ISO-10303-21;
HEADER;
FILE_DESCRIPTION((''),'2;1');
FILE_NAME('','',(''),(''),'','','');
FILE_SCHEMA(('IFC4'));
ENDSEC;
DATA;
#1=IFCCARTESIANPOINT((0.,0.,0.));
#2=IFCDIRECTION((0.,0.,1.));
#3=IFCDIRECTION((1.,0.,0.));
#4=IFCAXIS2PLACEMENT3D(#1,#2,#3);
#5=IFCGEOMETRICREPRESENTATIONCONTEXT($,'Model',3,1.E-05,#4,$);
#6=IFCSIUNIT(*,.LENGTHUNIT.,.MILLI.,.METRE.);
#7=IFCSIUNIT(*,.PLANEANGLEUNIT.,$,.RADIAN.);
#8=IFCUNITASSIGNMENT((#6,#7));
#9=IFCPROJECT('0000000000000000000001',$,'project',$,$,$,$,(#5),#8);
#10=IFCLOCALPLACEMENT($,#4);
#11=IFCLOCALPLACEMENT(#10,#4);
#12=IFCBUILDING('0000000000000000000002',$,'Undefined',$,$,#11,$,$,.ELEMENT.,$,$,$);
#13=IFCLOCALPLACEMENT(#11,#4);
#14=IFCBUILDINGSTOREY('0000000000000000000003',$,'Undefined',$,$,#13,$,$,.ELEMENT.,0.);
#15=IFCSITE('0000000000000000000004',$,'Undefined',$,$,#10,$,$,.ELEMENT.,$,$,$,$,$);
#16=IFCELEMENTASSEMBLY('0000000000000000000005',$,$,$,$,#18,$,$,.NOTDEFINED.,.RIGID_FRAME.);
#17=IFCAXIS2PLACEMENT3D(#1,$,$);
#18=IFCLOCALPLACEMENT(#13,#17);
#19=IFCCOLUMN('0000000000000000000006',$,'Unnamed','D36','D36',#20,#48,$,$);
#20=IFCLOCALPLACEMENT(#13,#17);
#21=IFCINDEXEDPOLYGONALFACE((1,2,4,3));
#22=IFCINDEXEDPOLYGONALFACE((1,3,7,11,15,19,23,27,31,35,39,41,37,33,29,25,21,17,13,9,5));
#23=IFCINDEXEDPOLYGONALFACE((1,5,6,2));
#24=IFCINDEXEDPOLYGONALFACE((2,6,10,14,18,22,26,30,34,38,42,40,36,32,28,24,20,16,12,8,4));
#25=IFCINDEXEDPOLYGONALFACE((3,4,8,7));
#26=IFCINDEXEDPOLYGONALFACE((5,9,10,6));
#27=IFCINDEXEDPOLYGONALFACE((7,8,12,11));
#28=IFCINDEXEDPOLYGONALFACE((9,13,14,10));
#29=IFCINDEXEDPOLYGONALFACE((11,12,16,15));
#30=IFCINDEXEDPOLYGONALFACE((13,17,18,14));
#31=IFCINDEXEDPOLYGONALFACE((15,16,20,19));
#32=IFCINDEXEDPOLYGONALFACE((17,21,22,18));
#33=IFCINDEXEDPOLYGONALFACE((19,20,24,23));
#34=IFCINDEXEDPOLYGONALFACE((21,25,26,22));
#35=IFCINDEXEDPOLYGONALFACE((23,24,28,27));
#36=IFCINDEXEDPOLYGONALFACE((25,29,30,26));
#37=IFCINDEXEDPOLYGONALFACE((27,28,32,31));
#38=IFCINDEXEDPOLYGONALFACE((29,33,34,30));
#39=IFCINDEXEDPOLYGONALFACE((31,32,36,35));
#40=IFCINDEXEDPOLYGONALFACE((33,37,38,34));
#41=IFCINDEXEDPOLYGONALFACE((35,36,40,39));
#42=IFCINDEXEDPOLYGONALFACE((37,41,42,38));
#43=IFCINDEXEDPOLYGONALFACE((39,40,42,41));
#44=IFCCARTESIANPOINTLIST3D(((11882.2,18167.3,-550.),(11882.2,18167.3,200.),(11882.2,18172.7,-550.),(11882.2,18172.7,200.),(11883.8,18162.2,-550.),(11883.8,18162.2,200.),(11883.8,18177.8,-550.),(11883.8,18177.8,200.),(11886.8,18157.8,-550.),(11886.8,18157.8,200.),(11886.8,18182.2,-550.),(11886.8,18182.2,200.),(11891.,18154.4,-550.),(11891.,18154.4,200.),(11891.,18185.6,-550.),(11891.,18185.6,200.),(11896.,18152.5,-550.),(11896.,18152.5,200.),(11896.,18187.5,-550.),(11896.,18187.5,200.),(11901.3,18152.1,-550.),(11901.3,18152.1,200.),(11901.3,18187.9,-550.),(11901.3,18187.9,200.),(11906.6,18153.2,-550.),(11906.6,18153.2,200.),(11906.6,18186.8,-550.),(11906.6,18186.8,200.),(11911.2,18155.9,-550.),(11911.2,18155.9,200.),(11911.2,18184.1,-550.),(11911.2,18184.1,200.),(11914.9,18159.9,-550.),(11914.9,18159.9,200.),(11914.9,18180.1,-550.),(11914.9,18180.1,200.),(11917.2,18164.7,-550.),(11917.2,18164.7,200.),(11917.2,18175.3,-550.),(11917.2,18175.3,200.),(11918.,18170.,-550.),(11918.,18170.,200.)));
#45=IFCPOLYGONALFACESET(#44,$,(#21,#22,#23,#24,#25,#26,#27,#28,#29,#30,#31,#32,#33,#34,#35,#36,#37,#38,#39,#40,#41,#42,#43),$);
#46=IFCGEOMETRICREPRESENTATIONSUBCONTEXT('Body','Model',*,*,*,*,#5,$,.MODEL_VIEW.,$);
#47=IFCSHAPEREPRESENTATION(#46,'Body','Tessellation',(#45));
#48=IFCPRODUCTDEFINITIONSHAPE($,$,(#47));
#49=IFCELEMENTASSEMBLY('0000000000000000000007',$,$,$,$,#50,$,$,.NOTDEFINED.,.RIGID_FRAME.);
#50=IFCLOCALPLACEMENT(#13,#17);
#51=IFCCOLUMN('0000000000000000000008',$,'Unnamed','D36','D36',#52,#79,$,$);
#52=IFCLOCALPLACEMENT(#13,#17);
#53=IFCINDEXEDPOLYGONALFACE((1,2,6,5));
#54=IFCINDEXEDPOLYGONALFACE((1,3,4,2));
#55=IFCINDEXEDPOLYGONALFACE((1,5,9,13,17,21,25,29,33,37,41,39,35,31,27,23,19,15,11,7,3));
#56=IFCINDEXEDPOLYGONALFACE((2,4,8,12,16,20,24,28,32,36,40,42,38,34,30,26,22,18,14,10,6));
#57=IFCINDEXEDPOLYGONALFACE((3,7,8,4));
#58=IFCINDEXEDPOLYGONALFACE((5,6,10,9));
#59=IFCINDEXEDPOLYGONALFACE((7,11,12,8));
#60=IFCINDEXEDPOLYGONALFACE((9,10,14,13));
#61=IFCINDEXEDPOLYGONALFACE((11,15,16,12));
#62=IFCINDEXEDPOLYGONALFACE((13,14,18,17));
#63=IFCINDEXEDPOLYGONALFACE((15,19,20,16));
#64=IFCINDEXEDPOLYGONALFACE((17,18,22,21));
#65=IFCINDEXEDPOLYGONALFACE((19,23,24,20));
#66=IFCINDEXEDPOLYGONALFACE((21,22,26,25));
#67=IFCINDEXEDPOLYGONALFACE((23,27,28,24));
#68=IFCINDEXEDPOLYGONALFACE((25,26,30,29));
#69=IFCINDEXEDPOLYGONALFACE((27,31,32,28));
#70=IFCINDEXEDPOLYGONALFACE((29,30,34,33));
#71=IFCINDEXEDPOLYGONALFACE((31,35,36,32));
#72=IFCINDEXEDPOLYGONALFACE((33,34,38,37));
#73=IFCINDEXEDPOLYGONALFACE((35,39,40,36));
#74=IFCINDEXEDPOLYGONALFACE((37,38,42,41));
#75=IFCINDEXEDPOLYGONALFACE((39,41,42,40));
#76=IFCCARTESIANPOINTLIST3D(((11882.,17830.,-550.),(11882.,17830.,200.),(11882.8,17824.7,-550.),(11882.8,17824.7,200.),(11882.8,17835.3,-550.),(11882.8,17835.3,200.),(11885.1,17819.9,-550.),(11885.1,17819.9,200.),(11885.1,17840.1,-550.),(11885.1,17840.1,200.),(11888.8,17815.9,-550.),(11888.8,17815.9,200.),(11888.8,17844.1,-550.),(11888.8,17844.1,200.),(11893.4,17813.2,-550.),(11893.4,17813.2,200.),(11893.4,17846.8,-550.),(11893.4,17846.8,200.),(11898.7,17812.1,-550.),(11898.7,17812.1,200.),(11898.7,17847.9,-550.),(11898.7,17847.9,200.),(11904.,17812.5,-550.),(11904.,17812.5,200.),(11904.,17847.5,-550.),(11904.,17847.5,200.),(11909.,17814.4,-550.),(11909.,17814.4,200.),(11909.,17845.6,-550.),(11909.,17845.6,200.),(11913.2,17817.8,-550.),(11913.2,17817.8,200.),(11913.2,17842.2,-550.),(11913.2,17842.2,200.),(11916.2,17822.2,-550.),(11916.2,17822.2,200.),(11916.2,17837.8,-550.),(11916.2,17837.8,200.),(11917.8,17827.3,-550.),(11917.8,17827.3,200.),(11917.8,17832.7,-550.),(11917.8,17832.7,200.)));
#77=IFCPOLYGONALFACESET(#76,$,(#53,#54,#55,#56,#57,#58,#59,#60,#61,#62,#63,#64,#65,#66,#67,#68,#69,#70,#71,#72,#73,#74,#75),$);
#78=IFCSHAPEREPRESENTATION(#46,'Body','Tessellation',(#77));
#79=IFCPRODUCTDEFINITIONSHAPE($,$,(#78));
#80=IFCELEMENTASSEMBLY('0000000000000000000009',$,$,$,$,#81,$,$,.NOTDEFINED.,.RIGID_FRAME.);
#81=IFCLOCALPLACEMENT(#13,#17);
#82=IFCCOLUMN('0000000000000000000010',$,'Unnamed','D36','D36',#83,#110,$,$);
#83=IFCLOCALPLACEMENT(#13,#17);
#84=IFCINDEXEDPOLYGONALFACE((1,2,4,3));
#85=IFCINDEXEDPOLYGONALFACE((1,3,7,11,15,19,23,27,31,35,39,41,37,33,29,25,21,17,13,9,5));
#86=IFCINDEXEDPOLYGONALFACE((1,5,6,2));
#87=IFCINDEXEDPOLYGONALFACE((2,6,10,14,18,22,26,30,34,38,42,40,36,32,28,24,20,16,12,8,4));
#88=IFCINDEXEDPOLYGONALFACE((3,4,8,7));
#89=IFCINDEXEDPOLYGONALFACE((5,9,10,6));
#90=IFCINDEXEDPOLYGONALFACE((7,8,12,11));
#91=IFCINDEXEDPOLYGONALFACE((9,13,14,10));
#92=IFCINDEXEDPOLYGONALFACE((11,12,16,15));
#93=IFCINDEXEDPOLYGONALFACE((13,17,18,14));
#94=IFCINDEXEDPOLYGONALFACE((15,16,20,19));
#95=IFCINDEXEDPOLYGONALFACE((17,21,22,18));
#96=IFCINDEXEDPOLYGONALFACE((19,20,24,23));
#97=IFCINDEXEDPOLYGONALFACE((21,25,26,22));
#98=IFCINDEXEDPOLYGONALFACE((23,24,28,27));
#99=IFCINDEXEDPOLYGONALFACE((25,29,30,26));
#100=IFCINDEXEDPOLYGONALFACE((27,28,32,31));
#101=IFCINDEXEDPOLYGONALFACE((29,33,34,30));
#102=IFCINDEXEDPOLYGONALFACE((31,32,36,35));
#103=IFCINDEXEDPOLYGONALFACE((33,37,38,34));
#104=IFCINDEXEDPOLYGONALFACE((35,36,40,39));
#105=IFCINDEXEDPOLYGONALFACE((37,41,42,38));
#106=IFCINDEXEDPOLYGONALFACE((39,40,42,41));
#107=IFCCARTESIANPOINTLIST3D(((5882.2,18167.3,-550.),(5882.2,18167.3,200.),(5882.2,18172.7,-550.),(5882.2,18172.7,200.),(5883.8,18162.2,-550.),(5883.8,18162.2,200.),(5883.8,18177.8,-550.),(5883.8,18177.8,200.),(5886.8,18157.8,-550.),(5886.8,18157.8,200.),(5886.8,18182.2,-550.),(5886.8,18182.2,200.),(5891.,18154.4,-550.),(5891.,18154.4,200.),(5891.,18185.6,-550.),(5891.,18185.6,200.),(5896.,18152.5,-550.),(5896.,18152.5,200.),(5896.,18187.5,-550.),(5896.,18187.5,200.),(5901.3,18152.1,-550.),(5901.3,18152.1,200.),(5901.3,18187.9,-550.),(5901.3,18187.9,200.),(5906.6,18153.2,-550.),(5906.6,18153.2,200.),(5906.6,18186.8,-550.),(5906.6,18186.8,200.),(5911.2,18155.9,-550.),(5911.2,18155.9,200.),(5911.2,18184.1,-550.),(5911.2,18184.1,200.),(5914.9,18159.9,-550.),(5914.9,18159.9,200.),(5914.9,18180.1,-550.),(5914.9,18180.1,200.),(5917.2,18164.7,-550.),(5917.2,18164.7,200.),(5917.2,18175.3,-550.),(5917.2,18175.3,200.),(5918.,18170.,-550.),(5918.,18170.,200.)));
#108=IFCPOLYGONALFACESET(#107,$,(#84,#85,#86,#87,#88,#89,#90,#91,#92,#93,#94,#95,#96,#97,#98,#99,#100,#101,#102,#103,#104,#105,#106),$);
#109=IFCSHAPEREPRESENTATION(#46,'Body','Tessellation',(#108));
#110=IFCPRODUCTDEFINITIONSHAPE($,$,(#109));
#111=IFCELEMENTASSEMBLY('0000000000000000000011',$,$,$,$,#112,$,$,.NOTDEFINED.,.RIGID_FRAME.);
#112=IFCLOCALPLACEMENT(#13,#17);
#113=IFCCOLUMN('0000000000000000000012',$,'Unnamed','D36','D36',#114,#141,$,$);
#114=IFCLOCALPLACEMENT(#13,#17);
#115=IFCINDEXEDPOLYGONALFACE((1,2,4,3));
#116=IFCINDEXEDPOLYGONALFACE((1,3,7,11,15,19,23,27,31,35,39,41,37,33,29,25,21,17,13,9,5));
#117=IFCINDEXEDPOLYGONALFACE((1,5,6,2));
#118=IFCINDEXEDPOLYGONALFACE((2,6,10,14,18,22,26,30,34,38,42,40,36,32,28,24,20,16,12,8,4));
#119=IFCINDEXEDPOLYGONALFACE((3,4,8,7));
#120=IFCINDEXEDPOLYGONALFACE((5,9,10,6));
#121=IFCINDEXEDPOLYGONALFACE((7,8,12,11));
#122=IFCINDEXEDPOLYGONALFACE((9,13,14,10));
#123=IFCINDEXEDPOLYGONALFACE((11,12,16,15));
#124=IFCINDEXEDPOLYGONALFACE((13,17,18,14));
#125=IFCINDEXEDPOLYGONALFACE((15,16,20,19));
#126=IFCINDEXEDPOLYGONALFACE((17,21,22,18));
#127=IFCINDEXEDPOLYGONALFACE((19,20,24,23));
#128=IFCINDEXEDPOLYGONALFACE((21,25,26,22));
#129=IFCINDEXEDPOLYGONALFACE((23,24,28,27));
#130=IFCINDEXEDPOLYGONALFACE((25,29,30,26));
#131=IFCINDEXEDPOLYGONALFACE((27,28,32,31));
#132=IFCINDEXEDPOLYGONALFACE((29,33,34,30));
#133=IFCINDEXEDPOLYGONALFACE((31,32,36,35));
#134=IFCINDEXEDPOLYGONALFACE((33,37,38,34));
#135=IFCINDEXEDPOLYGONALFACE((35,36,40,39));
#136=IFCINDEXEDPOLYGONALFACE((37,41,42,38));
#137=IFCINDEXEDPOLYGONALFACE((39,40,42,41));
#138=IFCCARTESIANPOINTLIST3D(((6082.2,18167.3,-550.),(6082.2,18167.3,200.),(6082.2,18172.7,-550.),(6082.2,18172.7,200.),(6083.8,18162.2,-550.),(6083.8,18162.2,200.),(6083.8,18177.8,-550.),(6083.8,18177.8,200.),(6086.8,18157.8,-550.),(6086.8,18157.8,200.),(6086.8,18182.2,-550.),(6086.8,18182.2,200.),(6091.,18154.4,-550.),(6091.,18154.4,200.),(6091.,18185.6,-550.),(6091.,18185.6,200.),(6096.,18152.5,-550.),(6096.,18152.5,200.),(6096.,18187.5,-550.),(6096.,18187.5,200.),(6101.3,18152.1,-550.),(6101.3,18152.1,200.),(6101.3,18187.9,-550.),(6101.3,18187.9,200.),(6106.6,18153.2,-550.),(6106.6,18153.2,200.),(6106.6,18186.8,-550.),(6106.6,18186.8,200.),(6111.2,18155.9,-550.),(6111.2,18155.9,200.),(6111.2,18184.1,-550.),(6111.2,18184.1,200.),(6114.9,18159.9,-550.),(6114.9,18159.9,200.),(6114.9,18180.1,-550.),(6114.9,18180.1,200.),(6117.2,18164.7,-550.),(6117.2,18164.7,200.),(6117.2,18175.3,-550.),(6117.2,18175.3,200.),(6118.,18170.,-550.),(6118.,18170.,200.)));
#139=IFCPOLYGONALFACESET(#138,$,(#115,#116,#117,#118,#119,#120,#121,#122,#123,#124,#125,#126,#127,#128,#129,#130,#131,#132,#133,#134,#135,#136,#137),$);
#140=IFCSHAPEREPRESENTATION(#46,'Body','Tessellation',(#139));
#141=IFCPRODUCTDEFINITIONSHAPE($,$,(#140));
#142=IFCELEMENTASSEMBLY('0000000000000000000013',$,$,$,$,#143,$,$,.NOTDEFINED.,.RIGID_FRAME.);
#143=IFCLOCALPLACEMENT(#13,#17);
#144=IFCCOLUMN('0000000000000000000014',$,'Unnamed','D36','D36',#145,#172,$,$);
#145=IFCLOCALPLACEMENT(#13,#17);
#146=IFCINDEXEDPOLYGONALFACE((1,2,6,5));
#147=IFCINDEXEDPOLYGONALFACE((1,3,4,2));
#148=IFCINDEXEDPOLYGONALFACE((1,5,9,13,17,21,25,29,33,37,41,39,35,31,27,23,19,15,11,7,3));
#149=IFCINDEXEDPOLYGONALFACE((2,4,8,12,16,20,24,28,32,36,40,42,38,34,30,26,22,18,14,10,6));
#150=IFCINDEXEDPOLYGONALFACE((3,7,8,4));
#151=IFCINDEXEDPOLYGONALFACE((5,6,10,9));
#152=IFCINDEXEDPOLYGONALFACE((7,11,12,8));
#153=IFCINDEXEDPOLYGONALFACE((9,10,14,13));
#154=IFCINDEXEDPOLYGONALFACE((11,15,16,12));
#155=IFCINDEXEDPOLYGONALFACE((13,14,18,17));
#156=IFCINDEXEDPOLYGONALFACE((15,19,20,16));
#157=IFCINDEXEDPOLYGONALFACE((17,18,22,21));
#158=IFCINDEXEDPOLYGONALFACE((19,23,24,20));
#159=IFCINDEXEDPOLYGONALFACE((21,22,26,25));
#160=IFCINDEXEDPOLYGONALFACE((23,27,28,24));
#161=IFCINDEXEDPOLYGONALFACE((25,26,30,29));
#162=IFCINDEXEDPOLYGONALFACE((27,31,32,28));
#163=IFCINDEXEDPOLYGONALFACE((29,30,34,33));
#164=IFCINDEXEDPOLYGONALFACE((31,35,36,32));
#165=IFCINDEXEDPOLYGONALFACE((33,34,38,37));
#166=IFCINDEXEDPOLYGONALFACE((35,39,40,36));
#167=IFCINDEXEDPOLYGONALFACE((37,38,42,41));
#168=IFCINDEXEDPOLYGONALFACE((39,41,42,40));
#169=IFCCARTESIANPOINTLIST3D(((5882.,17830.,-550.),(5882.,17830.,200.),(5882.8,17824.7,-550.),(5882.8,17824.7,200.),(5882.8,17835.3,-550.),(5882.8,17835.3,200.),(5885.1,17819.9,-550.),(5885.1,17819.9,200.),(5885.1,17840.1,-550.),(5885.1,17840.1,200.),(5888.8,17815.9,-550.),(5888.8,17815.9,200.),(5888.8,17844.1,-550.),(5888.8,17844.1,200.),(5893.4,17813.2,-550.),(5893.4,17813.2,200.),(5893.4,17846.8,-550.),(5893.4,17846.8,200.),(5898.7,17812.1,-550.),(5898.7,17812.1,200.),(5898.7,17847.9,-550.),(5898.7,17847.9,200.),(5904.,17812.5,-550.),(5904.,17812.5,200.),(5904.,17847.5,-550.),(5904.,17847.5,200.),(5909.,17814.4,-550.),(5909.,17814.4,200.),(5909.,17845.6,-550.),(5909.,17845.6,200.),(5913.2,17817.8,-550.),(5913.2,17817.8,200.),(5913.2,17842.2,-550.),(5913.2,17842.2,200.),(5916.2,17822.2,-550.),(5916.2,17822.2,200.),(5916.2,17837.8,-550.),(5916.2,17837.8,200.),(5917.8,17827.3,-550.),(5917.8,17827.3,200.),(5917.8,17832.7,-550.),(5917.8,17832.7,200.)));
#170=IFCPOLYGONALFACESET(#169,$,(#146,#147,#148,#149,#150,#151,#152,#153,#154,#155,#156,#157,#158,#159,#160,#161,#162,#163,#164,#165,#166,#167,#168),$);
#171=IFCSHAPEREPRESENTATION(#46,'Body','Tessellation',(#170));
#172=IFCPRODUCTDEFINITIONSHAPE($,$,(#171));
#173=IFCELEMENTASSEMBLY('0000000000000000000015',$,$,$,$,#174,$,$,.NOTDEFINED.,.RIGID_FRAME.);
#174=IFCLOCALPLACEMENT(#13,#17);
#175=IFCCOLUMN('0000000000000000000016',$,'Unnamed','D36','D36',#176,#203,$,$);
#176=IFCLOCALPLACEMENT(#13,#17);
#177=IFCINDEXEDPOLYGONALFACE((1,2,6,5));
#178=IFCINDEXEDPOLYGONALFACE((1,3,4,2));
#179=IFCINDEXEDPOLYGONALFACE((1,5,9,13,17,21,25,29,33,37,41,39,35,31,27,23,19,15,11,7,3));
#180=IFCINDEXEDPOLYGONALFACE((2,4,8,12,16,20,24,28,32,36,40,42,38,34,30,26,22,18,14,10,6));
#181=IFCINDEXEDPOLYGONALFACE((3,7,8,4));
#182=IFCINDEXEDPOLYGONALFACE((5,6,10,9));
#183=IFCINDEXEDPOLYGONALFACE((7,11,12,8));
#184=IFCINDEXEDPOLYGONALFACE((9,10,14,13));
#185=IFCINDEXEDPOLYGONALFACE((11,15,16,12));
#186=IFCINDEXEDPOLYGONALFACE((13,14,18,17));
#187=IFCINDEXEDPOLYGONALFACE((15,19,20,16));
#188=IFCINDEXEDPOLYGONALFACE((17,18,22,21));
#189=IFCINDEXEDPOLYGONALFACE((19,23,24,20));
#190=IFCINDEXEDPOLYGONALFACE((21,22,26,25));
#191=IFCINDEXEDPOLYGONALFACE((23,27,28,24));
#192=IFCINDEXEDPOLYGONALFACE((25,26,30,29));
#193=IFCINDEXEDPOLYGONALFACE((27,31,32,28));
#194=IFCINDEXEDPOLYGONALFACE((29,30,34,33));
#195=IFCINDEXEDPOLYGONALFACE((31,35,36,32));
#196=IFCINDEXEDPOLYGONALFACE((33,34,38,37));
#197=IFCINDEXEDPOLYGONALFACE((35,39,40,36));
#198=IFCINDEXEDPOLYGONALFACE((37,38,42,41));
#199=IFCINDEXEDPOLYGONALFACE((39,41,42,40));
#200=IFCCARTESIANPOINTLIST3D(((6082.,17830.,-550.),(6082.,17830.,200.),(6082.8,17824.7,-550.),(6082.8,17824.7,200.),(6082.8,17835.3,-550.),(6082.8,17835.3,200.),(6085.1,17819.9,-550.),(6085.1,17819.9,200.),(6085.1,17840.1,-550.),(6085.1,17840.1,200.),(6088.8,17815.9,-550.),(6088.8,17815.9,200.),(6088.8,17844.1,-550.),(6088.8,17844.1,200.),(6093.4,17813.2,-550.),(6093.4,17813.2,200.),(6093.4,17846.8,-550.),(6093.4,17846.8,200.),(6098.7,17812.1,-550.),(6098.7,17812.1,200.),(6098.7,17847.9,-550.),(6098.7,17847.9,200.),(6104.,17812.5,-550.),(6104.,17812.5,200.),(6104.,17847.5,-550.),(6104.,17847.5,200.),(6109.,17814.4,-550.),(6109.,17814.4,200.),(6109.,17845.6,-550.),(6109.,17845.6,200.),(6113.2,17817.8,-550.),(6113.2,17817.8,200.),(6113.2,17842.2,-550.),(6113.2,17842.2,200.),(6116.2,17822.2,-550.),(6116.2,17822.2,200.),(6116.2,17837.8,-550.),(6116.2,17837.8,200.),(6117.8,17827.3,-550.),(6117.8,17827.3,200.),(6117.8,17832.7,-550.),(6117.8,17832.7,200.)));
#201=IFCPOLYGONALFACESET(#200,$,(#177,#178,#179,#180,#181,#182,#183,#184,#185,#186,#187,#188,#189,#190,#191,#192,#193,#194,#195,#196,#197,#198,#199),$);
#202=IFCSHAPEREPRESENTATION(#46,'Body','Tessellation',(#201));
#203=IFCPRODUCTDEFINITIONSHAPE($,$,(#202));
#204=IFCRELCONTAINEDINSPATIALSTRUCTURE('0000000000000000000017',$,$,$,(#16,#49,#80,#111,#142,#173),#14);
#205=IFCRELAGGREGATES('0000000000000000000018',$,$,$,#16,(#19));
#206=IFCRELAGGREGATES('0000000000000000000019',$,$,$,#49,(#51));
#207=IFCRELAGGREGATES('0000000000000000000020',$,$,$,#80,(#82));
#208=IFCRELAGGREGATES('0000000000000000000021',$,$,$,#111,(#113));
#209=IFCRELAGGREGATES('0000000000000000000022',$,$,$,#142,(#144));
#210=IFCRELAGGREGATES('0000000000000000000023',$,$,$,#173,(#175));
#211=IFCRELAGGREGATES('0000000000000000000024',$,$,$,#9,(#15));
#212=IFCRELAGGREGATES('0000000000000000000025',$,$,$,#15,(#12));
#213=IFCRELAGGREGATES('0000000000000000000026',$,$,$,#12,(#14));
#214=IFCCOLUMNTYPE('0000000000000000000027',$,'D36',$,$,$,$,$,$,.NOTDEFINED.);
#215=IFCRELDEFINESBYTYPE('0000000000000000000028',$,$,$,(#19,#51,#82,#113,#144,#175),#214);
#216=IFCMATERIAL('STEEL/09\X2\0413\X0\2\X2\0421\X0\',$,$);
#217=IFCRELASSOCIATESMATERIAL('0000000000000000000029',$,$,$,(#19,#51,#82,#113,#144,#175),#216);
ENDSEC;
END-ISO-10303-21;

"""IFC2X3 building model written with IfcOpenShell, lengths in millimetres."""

from ifc_helpers import new_model, si_unit, frame, origin_with_axes, origin_2d_with_axis, place, context, subcontext, project, spatial, circle, extrude, material, type_object, element, aggregate, save


model = new_model("IFC2X3")

# Units and contexts
model_context = context("Model", 3, precision=1e-05, world=origin_with_axes())
body_context = subcontext(model_context, "Body", "Model", "MODEL_VIEW")
ifc_project = project(units=[si_unit("LENGTHUNIT", "METRE", prefix="MILLI"), si_unit("PLANEANGLEUNIT", "RADIAN")], contexts=[model_context])

# Site, building, storey
site_placement = place(None, origin_with_axes())
site = spatial("IfcSite", under=ifc_project, at=site_placement, Name="Undefined", CompositionType="ELEMENT")
building_placement = place(site_placement, origin_with_axes())
building = spatial("IfcBuilding", under=site, at=building_placement, Name="Undefined", CompositionType="ELEMENT")
storey_placement = place(building_placement, origin_with_axes())
storey = spatial("IfcBuildingStorey", under=building, at=storey_placement, Name="Undefined", CompositionType="ELEMENT", Elevation=0.0)

# Element assemblies, columns
assembly_1_placement = place(storey_placement, origin_with_axes())
assembly_1 = element("IfcElementAssembly", 1, at=assembly_1_placement, inside=storey, AssemblyPlace="NOTDEFINED", PredefinedType="RIGID_FRAME")
ifc_material_1 = material(Name="STEEL/09Г2С")
column_type_1 = type_object("IfcColumnType", Name="D36", PredefinedType="NOTDEFINED")
column_1_placement = place(assembly_1_placement, frame((11900.0, 18170.0, -550.0), z_axis=(0.0, 0.0, 1.0), x_axis=(0.0, -1.0, 0.0)))
column_1 = element("IfcColumn", 2, at=column_1_placement, type_object=column_type_1, material=ifc_material_1, Name="Unnamed", Description="D36", ObjectType="D36", context=body_context, shape_type="SweptSolid", body=[
    extrude(circle(Radius=18.0, at=origin_2d_with_axis()), frame((0.0, 0.0, 750.0), z_axis=(0.0, 0.0, -1.0), x_axis=(0.0, 1.0, 0.0)), (0.0, 0.0, 1.0), 750.0),
])
aggregate(assembly_1, [column_1])
assembly_2_placement = place(storey_placement, origin_with_axes())
assembly_2 = element("IfcElementAssembly", 3, at=assembly_2_placement, inside=storey, AssemblyPlace="NOTDEFINED", PredefinedType="RIGID_FRAME")
column_2_placement = place(assembly_2_placement, frame((11900.0, 17830.0, -550.0), z_axis=(0.0, 0.0, 1.0), x_axis=(0.0, 1.0, 0.0)))
column_2 = element("IfcColumn", 4, at=column_2_placement, type_object=column_type_1, material=ifc_material_1, Name="Unnamed", Description="D36", ObjectType="D36", context=body_context, shape_type="SweptSolid", body=[
    extrude(circle(Radius=18.0, at=origin_2d_with_axis()), frame((0.0, 0.0, 750.0), z_axis=(0.0, 0.0, -1.0), x_axis=(0.0, 1.0, 0.0)), (0.0, 0.0, 1.0), 750.0),
])
aggregate(assembly_2, [column_2])
assembly_3_placement = place(storey_placement, origin_with_axes())
assembly_3 = element("IfcElementAssembly", 5, at=assembly_3_placement, inside=storey, AssemblyPlace="NOTDEFINED", PredefinedType="RIGID_FRAME")
column_3_placement = place(assembly_3_placement, frame((5900.0, 18170.0, -550.0), z_axis=(0.0, 0.0, 1.0), x_axis=(0.0, -1.0, 0.0)))
column_3 = element("IfcColumn", 6, at=column_3_placement, type_object=column_type_1, material=ifc_material_1, Name="Unnamed", Description="D36", ObjectType="D36", context=body_context, shape_type="SweptSolid", body=[
    extrude(circle(Radius=18.0, at=origin_2d_with_axis()), frame((0.0, 0.0, 750.0), z_axis=(0.0, 0.0, -1.0), x_axis=(0.0, 1.0, 0.0)), (0.0, 0.0, 1.0), 750.0),
])
aggregate(assembly_3, [column_3])
assembly_4_placement = place(storey_placement, origin_with_axes())
assembly_4 = element("IfcElementAssembly", 7, at=assembly_4_placement, inside=storey, AssemblyPlace="NOTDEFINED", PredefinedType="RIGID_FRAME")
column_4_placement = place(assembly_4_placement, frame((6100.0, 18170.0, -550.0), z_axis=(0.0, 0.0, 1.0), x_axis=(0.0, -1.0, 0.0)))
column_4 = element("IfcColumn", 8, at=column_4_placement, type_object=column_type_1, material=ifc_material_1, Name="Unnamed", Description="D36", ObjectType="D36", context=body_context, shape_type="SweptSolid", body=[
    extrude(circle(Radius=18.0, at=origin_2d_with_axis()), frame((0.0, 0.0, 750.0), z_axis=(0.0, 0.0, -1.0), x_axis=(0.0, 1.0, 0.0)), (0.0, 0.0, 1.0), 750.0),
])
aggregate(assembly_4, [column_4])
assembly_5_placement = place(storey_placement, origin_with_axes())
assembly_5 = element("IfcElementAssembly", 9, at=assembly_5_placement, inside=storey, AssemblyPlace="NOTDEFINED", PredefinedType="RIGID_FRAME")
column_5_placement = place(assembly_5_placement, frame((5900.0, 17830.0, -550.0), z_axis=(0.0, 0.0, 1.0), x_axis=(0.0, 1.0, 0.0)))
column_5 = element("IfcColumn", 10, at=column_5_placement, type_object=column_type_1, material=ifc_material_1, Name="Unnamed", Description="D36", ObjectType="D36", context=body_context, shape_type="SweptSolid", body=[
    extrude(circle(Radius=18.0, at=origin_2d_with_axis()), frame((0.0, 0.0, 750.0), z_axis=(0.0, 0.0, -1.0), x_axis=(0.0, 1.0, 0.0)), (0.0, 0.0, 1.0), 750.0),
])
aggregate(assembly_5, [column_5])
assembly_6_placement = place(storey_placement, origin_with_axes())
assembly_6 = element("IfcElementAssembly", 11, at=assembly_6_placement, inside=storey, AssemblyPlace="NOTDEFINED", PredefinedType="RIGID_FRAME")
column_6_placement = place(assembly_6_placement, frame((6100.0, 17830.0, -550.0), z_axis=(0.0, 0.0, 1.0), x_axis=(0.0, 1.0, 0.0)))
column_6 = element("IfcColumn", 12, at=column_6_placement, type_object=column_type_1, material=ifc_material_1, Name="Unnamed", Description="D36", ObjectType="D36", context=body_context, shape_type="SweptSolid", body=[
    extrude(circle(Radius=18.0, at=origin_2d_with_axis()), frame((0.0, 0.0, 750.0), z_axis=(0.0, 0.0, -1.0), x_axis=(0.0, 1.0, 0.0)), (0.0, 0.0, 1.0), 750.0),
])
aggregate(assembly_6, [column_6])

save(model, "model.ifc")
